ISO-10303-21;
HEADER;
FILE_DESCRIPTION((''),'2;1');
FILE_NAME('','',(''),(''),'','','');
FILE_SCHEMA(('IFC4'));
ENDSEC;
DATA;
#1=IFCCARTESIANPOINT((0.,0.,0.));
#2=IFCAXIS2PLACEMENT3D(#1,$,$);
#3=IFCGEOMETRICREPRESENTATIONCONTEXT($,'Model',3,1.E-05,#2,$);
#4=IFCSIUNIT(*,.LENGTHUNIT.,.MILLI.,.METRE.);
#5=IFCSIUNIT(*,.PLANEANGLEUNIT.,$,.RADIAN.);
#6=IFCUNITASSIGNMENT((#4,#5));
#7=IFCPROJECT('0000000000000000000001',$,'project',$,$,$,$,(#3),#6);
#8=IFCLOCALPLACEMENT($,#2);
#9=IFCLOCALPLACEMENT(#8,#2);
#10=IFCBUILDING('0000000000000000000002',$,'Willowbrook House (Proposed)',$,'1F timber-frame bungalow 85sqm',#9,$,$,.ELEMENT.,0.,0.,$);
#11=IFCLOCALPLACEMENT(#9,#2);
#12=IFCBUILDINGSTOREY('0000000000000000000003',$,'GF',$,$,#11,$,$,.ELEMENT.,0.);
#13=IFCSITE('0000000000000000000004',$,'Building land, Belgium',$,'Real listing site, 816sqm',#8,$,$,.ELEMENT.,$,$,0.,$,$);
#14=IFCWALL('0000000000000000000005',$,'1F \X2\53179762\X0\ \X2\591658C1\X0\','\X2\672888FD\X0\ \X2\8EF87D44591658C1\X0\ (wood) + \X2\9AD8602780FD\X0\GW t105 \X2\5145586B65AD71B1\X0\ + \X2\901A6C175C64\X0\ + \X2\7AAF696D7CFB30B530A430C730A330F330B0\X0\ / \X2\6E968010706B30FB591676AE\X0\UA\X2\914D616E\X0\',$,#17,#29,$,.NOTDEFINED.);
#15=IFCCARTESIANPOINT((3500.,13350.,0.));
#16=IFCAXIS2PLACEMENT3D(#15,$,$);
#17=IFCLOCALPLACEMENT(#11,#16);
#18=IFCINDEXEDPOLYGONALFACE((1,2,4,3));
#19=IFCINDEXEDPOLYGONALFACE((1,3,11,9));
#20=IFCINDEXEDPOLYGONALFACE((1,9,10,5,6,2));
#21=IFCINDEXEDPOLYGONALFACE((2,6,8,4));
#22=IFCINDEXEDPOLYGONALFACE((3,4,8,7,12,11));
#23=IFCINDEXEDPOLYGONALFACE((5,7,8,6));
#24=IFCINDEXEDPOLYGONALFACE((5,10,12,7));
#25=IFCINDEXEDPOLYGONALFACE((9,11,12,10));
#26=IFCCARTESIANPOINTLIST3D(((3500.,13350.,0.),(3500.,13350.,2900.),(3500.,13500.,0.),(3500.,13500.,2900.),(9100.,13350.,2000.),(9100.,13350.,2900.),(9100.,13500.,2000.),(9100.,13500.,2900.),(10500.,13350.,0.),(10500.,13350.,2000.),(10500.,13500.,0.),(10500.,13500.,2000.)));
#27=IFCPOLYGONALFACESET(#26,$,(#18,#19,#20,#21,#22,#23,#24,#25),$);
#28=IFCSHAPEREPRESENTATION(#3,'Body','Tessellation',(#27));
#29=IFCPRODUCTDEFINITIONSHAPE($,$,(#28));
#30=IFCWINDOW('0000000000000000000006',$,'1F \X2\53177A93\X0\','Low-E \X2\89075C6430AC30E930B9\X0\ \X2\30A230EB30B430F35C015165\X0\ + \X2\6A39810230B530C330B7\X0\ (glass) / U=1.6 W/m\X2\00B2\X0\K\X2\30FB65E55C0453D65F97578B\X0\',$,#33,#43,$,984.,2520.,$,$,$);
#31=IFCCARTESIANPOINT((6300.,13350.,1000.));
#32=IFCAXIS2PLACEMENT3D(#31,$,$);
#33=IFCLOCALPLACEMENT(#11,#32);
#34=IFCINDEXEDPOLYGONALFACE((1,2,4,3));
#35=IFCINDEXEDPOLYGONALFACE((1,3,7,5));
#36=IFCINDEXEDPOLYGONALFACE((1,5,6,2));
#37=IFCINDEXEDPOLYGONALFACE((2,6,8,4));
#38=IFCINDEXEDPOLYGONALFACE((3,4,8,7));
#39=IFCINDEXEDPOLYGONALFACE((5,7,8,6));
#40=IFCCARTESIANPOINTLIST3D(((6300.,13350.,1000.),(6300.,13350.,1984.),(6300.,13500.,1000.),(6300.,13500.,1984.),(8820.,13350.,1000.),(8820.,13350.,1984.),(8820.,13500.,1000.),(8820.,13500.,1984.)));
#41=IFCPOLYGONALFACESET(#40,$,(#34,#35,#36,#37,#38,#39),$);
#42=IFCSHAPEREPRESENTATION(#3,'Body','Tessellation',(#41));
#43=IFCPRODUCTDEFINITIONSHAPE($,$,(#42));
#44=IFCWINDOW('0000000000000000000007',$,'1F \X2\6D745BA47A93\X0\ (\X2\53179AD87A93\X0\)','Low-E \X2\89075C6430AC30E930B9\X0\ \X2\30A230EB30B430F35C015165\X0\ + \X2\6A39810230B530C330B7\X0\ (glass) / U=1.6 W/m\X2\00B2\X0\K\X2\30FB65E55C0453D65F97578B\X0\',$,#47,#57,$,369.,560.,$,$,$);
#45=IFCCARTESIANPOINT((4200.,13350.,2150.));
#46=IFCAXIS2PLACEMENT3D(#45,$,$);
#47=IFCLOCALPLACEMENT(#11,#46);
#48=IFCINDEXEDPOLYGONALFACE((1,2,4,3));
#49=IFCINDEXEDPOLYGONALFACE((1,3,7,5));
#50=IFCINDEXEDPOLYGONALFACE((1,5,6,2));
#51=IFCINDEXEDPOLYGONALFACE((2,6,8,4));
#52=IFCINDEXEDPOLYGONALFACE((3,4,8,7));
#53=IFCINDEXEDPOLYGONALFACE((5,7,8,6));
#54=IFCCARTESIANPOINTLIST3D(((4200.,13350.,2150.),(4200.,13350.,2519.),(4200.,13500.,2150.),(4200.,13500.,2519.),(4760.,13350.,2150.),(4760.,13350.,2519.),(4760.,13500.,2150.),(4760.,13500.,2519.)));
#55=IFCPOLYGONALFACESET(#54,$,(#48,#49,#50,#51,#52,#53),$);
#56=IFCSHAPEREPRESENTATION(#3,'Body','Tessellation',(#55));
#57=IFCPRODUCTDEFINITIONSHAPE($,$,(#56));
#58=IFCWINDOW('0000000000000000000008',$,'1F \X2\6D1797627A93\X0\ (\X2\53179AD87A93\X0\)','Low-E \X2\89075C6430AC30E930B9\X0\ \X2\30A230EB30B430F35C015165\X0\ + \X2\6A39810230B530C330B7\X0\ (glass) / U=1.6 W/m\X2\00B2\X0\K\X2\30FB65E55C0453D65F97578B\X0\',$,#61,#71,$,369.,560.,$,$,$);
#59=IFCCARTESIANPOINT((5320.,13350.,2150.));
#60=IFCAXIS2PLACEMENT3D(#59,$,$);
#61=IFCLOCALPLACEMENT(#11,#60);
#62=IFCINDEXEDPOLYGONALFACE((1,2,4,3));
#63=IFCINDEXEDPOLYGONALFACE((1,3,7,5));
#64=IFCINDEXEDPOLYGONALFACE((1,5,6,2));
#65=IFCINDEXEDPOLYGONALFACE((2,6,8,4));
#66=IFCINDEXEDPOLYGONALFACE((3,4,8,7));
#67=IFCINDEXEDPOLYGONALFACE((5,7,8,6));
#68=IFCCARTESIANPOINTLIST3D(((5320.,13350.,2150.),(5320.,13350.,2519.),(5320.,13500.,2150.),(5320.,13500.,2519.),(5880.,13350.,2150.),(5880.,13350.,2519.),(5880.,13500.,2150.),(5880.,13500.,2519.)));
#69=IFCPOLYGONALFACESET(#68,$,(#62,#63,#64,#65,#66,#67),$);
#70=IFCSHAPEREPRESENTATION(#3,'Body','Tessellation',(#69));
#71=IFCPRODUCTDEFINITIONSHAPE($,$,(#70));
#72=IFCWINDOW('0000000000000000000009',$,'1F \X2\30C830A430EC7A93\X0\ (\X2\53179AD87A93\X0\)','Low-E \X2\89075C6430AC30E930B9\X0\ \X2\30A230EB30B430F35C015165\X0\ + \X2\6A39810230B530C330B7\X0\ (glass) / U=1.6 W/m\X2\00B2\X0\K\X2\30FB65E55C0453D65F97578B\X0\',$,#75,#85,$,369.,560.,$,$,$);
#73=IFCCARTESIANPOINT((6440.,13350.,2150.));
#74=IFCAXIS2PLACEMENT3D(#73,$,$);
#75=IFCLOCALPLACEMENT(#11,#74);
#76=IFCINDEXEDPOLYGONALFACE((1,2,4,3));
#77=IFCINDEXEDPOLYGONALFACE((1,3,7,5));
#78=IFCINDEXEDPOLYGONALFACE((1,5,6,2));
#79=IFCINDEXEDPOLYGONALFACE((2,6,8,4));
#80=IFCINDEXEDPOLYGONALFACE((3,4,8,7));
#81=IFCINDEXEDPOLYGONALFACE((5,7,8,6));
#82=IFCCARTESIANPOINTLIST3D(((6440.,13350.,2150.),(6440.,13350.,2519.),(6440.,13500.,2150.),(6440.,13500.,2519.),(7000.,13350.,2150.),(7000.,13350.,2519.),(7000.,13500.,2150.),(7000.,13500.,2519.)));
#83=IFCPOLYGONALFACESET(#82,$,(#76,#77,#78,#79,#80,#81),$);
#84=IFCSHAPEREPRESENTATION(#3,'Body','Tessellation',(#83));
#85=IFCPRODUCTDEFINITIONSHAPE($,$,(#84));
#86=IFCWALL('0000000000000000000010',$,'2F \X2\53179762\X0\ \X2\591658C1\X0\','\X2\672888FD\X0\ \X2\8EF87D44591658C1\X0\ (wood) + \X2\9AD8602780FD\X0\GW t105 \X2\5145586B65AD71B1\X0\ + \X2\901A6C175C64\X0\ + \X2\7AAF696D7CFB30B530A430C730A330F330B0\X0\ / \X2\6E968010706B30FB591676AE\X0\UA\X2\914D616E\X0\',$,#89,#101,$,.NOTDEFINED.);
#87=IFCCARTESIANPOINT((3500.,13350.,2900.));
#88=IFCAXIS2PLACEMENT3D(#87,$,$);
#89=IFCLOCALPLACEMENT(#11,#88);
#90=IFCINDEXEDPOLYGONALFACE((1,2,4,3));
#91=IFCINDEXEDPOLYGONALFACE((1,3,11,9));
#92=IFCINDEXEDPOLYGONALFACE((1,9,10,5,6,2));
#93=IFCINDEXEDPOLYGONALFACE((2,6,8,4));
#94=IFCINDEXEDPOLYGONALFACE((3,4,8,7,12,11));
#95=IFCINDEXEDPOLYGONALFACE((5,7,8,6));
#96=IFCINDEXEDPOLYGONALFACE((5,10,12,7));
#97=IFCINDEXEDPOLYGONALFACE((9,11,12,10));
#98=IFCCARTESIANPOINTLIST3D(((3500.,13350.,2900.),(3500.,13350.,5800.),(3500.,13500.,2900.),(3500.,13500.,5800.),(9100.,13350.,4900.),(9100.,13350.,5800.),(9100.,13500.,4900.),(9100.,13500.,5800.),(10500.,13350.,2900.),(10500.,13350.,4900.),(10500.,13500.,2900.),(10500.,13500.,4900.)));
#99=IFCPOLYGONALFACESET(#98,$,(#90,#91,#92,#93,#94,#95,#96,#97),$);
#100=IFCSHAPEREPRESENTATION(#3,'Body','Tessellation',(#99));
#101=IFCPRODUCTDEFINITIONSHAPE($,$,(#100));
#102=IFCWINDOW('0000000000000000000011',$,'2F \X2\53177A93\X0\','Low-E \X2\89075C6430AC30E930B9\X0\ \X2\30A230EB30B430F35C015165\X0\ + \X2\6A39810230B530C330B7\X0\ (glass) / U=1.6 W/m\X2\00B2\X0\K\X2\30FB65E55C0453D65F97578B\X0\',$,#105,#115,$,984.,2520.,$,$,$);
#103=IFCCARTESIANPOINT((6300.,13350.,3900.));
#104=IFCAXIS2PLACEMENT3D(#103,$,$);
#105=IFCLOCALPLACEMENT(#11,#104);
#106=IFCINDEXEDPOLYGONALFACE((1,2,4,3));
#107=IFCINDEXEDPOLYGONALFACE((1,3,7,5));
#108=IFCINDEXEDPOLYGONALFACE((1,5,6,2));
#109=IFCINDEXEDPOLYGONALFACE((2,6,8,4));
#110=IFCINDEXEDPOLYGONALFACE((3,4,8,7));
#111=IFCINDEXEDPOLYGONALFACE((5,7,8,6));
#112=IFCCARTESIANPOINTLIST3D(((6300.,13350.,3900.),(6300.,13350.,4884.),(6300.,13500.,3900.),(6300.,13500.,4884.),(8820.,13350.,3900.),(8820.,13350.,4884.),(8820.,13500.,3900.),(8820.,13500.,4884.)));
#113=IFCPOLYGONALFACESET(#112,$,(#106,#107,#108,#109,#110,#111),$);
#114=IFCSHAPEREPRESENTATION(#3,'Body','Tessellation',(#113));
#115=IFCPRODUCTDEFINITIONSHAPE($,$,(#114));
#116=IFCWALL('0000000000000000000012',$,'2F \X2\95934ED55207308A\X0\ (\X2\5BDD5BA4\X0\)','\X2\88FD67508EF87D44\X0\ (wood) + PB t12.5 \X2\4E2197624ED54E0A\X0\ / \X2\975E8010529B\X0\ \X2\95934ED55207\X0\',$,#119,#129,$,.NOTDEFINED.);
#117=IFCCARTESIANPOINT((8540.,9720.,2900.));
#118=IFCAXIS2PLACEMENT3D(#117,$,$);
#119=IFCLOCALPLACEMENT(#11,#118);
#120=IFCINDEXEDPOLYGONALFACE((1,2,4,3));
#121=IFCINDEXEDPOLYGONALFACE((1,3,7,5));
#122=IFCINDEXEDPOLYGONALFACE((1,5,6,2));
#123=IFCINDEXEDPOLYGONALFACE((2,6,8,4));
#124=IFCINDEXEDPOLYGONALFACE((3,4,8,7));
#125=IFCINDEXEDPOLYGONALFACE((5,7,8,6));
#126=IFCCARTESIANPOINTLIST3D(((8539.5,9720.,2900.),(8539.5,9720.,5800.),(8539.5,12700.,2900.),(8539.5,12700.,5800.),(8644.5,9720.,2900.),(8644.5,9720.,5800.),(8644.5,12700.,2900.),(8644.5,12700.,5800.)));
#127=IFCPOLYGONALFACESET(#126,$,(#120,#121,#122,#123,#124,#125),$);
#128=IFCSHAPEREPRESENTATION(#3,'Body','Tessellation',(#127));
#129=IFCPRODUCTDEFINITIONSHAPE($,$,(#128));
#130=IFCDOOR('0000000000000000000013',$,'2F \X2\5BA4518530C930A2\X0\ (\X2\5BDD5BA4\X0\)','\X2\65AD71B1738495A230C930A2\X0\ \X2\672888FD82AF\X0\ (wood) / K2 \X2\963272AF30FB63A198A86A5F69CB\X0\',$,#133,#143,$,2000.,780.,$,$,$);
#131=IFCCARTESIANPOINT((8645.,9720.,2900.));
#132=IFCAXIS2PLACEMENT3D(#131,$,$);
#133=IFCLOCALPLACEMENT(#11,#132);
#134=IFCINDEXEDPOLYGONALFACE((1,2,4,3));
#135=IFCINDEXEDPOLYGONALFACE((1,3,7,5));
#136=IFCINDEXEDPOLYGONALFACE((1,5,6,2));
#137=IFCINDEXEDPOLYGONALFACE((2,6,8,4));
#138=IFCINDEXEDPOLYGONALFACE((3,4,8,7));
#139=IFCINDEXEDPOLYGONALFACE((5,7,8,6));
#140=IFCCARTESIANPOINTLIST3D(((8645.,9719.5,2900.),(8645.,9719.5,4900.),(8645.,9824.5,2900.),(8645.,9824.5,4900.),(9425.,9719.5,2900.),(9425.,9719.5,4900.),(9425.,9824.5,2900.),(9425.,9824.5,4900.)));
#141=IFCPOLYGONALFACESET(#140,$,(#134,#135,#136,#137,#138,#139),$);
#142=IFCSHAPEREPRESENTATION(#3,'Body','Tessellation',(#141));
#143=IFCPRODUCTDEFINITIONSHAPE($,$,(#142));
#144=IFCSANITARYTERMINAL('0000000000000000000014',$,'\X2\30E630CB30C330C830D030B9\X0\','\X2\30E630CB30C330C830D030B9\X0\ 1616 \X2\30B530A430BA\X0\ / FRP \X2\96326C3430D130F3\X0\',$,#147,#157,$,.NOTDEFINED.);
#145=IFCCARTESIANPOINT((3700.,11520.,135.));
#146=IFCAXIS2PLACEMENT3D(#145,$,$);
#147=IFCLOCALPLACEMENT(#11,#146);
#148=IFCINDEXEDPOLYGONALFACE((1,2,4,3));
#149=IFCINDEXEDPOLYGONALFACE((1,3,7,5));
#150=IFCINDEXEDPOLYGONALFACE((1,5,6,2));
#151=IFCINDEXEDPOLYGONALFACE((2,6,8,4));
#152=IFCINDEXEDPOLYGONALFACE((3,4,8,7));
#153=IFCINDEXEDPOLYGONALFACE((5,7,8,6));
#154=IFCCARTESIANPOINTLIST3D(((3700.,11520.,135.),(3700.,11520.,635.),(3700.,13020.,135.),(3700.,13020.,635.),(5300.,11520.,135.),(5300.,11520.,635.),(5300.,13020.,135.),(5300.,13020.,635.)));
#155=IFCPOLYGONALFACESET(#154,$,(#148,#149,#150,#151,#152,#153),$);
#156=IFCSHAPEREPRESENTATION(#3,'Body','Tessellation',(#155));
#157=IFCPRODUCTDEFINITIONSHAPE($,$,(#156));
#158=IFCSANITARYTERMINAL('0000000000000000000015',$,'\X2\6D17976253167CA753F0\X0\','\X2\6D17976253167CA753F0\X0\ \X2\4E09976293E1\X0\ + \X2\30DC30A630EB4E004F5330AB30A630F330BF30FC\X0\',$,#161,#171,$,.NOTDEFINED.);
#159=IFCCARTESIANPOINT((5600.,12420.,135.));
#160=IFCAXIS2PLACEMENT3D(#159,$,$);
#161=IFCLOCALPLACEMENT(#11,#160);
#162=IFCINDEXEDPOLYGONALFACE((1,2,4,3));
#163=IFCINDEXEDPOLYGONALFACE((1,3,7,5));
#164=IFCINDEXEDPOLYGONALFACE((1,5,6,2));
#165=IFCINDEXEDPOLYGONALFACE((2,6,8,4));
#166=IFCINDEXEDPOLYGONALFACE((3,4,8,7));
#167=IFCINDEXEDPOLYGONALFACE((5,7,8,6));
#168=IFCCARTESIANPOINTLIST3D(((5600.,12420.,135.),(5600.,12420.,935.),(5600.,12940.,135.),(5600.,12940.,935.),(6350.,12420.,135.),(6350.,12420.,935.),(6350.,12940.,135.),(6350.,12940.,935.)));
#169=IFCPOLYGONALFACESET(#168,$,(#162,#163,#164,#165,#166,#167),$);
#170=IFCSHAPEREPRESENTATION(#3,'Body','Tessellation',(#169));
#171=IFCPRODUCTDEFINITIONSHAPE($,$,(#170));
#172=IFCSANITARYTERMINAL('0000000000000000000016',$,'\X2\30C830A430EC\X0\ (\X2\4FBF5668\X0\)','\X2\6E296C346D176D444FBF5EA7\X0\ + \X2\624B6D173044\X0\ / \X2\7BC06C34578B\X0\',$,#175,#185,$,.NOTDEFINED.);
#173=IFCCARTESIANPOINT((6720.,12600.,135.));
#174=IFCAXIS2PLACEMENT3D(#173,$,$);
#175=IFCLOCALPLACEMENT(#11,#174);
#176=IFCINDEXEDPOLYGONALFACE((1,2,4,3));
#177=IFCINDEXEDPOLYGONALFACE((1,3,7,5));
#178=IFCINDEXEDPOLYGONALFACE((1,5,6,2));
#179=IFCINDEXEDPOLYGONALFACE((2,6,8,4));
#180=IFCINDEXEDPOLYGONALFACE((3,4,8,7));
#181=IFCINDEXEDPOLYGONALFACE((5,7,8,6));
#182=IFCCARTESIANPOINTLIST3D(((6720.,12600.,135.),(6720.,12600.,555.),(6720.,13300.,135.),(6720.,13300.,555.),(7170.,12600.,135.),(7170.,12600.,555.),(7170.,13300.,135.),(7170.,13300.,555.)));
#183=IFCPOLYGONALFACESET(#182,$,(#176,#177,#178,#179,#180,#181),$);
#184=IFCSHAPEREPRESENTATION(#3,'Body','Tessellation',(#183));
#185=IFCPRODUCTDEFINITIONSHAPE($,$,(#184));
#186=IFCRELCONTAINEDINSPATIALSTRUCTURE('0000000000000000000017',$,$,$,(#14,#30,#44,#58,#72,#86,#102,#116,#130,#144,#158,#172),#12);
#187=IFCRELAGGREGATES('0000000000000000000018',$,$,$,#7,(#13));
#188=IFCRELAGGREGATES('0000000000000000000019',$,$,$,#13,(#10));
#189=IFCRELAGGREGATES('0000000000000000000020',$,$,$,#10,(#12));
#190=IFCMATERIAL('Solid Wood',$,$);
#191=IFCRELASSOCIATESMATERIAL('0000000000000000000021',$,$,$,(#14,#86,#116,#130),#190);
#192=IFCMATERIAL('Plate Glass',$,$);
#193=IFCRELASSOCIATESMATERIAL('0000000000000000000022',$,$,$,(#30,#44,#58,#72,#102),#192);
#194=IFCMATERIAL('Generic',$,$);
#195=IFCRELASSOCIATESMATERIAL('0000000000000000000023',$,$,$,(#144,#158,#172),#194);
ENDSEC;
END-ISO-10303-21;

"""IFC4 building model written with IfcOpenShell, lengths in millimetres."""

from ifc_helpers import new_model, si_unit, frame, frame_2d, origin, place, context, project, spatial, rectangle, extrude, material, element, fill, save


model = new_model("IFC4")

# Units and contexts
model_context = context("Model", 3, precision=1e-05, world=origin())
ifc_project = project(units=[si_unit("LENGTHUNIT", "METRE", prefix="MILLI"), si_unit("PLANEANGLEUNIT", "RADIAN")], contexts=[model_context])

# Site, building, storey
site_placement = place(None, origin())
site = spatial("IfcSite", under=ifc_project, at=site_placement, Name="Building land, Belgium", ObjectType="Real listing site, 816sqm", CompositionType="ELEMENT", RefElevation=0.0)
building_placement = place(site_placement, origin())
building = spatial("IfcBuilding", under=site, at=building_placement, Name="Willowbrook House (Proposed)", ObjectType="1F timber-frame bungalow 85sqm", CompositionType="ELEMENT", ElevationOfRefHeight=0.0, ElevationOfTerrain=0.0)
storey_placement = place(building_placement, origin())
storey = spatial("IfcBuildingStorey", under=building, at=storey_placement, Name="GF", CompositionType="ELEMENT", Elevation=0.0)

# Wall, openings, windows
ifc_material_1 = material(Name="Solid Wood")
wall_1_placement = place(storey_placement, frame((3500.0, 13350.0, 0.0)))
wall_1 = element("IfcWall", 1, at=wall_1_placement, inside=storey, material=ifc_material_1, Name="1F 北面 外壁", Description="木製 軸組外壁 (wood) + 高性能GW t105 充填断熱 + 通気層 + 窯業系サイディング / 準耐火・外皮UA配慮", PredefinedType="NOTDEFINED", context=model_context, shape_type="SweptSolid", body=[
    extrude(rectangle(XDim=7000.0, YDim=150.0, at=frame_2d((3500.0, 75.0))), frame((3500.0, 13350.0, 0.0)), (0.0, 0.0, 1.0), 2900.0),
])
opening_1_placement = place(storey_placement, frame((6300.0, 13350.0, 1000.0)))
opening_1 = element("IfcOpeningElement", 2, at=opening_1_placement, cuts=wall_1, PredefinedType="NOTDEFINED", context=model_context, shape_type="SweptSolid", body=[
    extrude(rectangle(XDim=2520.0, YDim=150.0, at=frame_2d((1260.0, 75.0))), frame((6300.0, 13350.0, 1000.0)), (0.0, 0.0, 1.0), 984.0),
])
opening_2_placement = place(storey_placement, frame((4200.0, 13350.0, 2150.0)))
opening_2 = element("IfcOpeningElement", 3, at=opening_2_placement, cuts=wall_1, PredefinedType="NOTDEFINED", context=model_context, shape_type="SweptSolid", body=[
    extrude(rectangle(XDim=560.0, YDim=150.0, at=frame_2d((280.0, 75.0))), frame((4200.0, 13350.0, 2150.0)), (0.0, 0.0, 1.0), 369.0),
])
opening_3_placement = place(storey_placement, frame((5320.0, 13350.0, 2150.0)))
opening_3 = element("IfcOpeningElement", 4, at=opening_3_placement, cuts=wall_1, PredefinedType="NOTDEFINED", context=model_context, shape_type="SweptSolid", body=[
    extrude(rectangle(XDim=560.0, YDim=150.0, at=frame_2d((280.0, 75.0))), frame((5320.0, 13350.0, 2150.0)), (0.0, 0.0, 1.0), 369.0),
])
opening_4_placement = place(storey_placement, frame((6440.0, 13350.0, 2150.0)))
opening_4 = element("IfcOpeningElement", 5, at=opening_4_placement, cuts=wall_1, PredefinedType="NOTDEFINED", context=model_context, shape_type="SweptSolid", body=[
    extrude(rectangle(XDim=560.0, YDim=150.0, at=frame_2d((280.0, 75.0))), frame((6440.0, 13350.0, 2150.0)), (0.0, 0.0, 1.0), 369.0),
])
ifc_material_2 = material(Name="Plate Glass")
window_1_placement = place(storey_placement, frame((6300.0, 13350.0, 1000.0)))
window_1 = element("IfcWindow", 6, at=window_1_placement, inside=storey, material=ifc_material_2, Name="1F 北窓", Description="Low-E 複層ガラス アルゴン封入 + 樹脂サッシ (glass) / U=1.6 W/m²K・日射取得型", OverallHeight=984.0, OverallWidth=2520.0, context=model_context, shape_type="SweptSolid", body=[
    extrude(rectangle(XDim=2520.0, YDim=150.0, at=frame_2d((1260.0, 75.0))), frame((6300.0, 13350.0, 1000.0)), (0.0, 0.0, 1.0), 984.0),
])
fill(opening_1, window_1)
window_2_placement = place(storey_placement, frame((4200.0, 13350.0, 2150.0)))
window_2 = element("IfcWindow", 7, at=window_2_placement, inside=storey, material=ifc_material_2, Name="1F 浴室窓 (北高窓)", Description="Low-E 複層ガラス アルゴン封入 + 樹脂サッシ (glass) / U=1.6 W/m²K・日射取得型", OverallHeight=369.0, OverallWidth=560.0, context=model_context, shape_type="SweptSolid", body=[
    extrude(rectangle(XDim=560.0, YDim=150.0, at=frame_2d((280.0, 75.0))), frame((4200.0, 13350.0, 2150.0)), (0.0, 0.0, 1.0), 369.0),
])
fill(opening_2, window_2)
window_3_placement = place(storey_placement, frame((5320.0, 13350.0, 2150.0)))
window_3 = element("IfcWindow", 8, at=window_3_placement, inside=storey, material=ifc_material_2, Name="1F 洗面窓 (北高窓)", Description="Low-E 複層ガラス アルゴン封入 + 樹脂サッシ (glass) / U=1.6 W/m²K・日射取得型", OverallHeight=369.0, OverallWidth=560.0, context=model_context, shape_type="SweptSolid", body=[
    extrude(rectangle(XDim=560.0, YDim=150.0, at=frame_2d((280.0, 75.0))), frame((5320.0, 13350.0, 2150.0)), (0.0, 0.0, 1.0), 369.0),
])
fill(opening_3, window_3)
window_4_placement = place(storey_placement, frame((6440.0, 13350.0, 2150.0)))
window_4 = element("IfcWindow", 9, at=window_4_placement, inside=storey, material=ifc_material_2, Name="1F トイレ窓 (北高窓)", Description="Low-E 複層ガラス アルゴン封入 + 樹脂サッシ (glass) / U=1.6 W/m²K・日射取得型", OverallHeight=369.0, OverallWidth=560.0, context=model_context, shape_type="SweptSolid", body=[
    extrude(rectangle(XDim=560.0, YDim=150.0, at=frame_2d((280.0, 75.0))), frame((6440.0, 13350.0, 2150.0)), (0.0, 0.0, 1.0), 369.0),
])
fill(opening_4, window_4)

# Wall, opening, window
wall_2_placement = place(storey_placement, frame((3500.0, 13350.0, 2900.0)))
wall_2 = element("IfcWall", 10, at=wall_2_placement, inside=storey, material=ifc_material_1, Name="2F 北面 外壁", Description="木製 軸組外壁 (wood) + 高性能GW t105 充填断熱 + 通気層 + 窯業系サイディング / 準耐火・外皮UA配慮", PredefinedType="NOTDEFINED", context=model_context, shape_type="SweptSolid", body=[
    extrude(rectangle(XDim=7000.0, YDim=150.0, at=frame_2d((3500.0, 75.0))), frame((3500.0, 13350.0, 2900.0)), (0.0, 0.0, 1.0), 2900.0),
])
opening_5_placement = place(storey_placement, frame((6300.0, 13350.0, 3900.0)))
opening_5 = element("IfcOpeningElement", 11, at=opening_5_placement, cuts=wall_2, PredefinedType="NOTDEFINED", context=model_context, shape_type="SweptSolid", body=[
    extrude(rectangle(XDim=2520.0, YDim=150.0, at=frame_2d((1260.0, 75.0))), frame((6300.0, 13350.0, 3900.0)), (0.0, 0.0, 1.0), 984.0),
])
window_5_placement = place(storey_placement, frame((6300.0, 13350.0, 3900.0)))
window_5 = element("IfcWindow", 12, at=window_5_placement, inside=storey, material=ifc_material_2, Name="2F 北窓", Description="Low-E 複層ガラス アルゴン封入 + 樹脂サッシ (glass) / U=1.6 W/m²K・日射取得型", OverallHeight=984.0, OverallWidth=2520.0, context=model_context, shape_type="SweptSolid", body=[
    extrude(rectangle(XDim=2520.0, YDim=150.0, at=frame_2d((1260.0, 75.0))), frame((6300.0, 13350.0, 3900.0)), (0.0, 0.0, 1.0), 984.0),
])
fill(opening_5, window_5)

# Wall
wall_3_placement = place(storey_placement, frame((8540.0, 9720.0, 2900.0)))
element("IfcWall", 13, at=wall_3_placement, inside=storey, material=ifc_material_1, Name="2F 間仕切り (寝室)", Description="製材軸組 (wood) + PB t12.5 両面仕上 / 非耐力 間仕切", PredefinedType="NOTDEFINED", context=model_context, shape_type="SweptSolid", body=[
    extrude(rectangle(XDim=105.0, YDim=2980.0, at=frame_2d((52.0, 1490.0))), frame((8540.0, 9720.0, 2900.0)), (0.0, 0.0, 1.0), 2900.0),
])

# Door
door_1_placement = place(storey_placement, frame((8645.0, 9720.0, 2900.0)))
element("IfcDoor", 14, at=door_1_placement, inside=storey, material=ifc_material_1, Name="2F 室内ドア (寝室)", Description="断熱玄関ドア 木製芯 (wood) / K2 防犯・採風機構", OverallHeight=2000.0, OverallWidth=780.0, context=model_context, shape_type="SweptSolid", body=[
    extrude(rectangle(XDim=780.0, YDim=105.0, at=frame_2d((390.0, 52.0))), frame((8645.0, 9720.0, 2900.0)), (0.0, 0.0, 1.0), 2000.0),
])

# Sanitary terminals
ifc_material_3 = material(Name="Generic")
sanitary_terminal_1_placement = place(storey_placement, frame((3700.0, 11520.0, 135.0)))
element("IfcSanitaryTerminal", 15, at=sanitary_terminal_1_placement, inside=storey, material=ifc_material_3, Name="ユニットバス", Description="ユニットバス 1616 サイズ / FRP 防水パン", PredefinedType="NOTDEFINED", context=model_context, shape_type="SweptSolid", body=[
    extrude(rectangle(XDim=1600.0, YDim=1500.0, at=frame_2d((800.0, 750.0))), frame((3700.0, 11520.0, 135.0)), (0.0, 0.0, 1.0), 500.0),
])
sanitary_terminal_2_placement = place(storey_placement, frame((5600.0, 12420.0, 135.0)))
element("IfcSanitaryTerminal", 16, at=sanitary_terminal_2_placement, inside=storey, material=ifc_material_3, Name="洗面化粧台", Description="洗面化粧台 三面鏡 + ボウル一体カウンター", PredefinedType="NOTDEFINED", context=model_context, shape_type="SweptSolid", body=[
    extrude(rectangle(XDim=750.0, YDim=520.0, at=frame_2d((375.0, 260.0))), frame((5600.0, 12420.0, 135.0)), (0.0, 0.0, 1.0), 800.0),
])
sanitary_terminal_3_placement = place(storey_placement, frame((6720.0, 12600.0, 135.0)))
element("IfcSanitaryTerminal", 17, at=sanitary_terminal_3_placement, inside=storey, material=ifc_material_3, Name="トイレ (便器)", Description="温水洗浄便座 + 手洗い / 節水型", PredefinedType="NOTDEFINED", context=model_context, shape_type="SweptSolid", body=[
    extrude(rectangle(XDim=450.0, YDim=700.0, at=frame_2d((225.0, 350.0))), frame((6720.0, 12600.0, 135.0)), (0.0, 0.0, 1.0), 420.0),
])

save(model, "model.ifc")
